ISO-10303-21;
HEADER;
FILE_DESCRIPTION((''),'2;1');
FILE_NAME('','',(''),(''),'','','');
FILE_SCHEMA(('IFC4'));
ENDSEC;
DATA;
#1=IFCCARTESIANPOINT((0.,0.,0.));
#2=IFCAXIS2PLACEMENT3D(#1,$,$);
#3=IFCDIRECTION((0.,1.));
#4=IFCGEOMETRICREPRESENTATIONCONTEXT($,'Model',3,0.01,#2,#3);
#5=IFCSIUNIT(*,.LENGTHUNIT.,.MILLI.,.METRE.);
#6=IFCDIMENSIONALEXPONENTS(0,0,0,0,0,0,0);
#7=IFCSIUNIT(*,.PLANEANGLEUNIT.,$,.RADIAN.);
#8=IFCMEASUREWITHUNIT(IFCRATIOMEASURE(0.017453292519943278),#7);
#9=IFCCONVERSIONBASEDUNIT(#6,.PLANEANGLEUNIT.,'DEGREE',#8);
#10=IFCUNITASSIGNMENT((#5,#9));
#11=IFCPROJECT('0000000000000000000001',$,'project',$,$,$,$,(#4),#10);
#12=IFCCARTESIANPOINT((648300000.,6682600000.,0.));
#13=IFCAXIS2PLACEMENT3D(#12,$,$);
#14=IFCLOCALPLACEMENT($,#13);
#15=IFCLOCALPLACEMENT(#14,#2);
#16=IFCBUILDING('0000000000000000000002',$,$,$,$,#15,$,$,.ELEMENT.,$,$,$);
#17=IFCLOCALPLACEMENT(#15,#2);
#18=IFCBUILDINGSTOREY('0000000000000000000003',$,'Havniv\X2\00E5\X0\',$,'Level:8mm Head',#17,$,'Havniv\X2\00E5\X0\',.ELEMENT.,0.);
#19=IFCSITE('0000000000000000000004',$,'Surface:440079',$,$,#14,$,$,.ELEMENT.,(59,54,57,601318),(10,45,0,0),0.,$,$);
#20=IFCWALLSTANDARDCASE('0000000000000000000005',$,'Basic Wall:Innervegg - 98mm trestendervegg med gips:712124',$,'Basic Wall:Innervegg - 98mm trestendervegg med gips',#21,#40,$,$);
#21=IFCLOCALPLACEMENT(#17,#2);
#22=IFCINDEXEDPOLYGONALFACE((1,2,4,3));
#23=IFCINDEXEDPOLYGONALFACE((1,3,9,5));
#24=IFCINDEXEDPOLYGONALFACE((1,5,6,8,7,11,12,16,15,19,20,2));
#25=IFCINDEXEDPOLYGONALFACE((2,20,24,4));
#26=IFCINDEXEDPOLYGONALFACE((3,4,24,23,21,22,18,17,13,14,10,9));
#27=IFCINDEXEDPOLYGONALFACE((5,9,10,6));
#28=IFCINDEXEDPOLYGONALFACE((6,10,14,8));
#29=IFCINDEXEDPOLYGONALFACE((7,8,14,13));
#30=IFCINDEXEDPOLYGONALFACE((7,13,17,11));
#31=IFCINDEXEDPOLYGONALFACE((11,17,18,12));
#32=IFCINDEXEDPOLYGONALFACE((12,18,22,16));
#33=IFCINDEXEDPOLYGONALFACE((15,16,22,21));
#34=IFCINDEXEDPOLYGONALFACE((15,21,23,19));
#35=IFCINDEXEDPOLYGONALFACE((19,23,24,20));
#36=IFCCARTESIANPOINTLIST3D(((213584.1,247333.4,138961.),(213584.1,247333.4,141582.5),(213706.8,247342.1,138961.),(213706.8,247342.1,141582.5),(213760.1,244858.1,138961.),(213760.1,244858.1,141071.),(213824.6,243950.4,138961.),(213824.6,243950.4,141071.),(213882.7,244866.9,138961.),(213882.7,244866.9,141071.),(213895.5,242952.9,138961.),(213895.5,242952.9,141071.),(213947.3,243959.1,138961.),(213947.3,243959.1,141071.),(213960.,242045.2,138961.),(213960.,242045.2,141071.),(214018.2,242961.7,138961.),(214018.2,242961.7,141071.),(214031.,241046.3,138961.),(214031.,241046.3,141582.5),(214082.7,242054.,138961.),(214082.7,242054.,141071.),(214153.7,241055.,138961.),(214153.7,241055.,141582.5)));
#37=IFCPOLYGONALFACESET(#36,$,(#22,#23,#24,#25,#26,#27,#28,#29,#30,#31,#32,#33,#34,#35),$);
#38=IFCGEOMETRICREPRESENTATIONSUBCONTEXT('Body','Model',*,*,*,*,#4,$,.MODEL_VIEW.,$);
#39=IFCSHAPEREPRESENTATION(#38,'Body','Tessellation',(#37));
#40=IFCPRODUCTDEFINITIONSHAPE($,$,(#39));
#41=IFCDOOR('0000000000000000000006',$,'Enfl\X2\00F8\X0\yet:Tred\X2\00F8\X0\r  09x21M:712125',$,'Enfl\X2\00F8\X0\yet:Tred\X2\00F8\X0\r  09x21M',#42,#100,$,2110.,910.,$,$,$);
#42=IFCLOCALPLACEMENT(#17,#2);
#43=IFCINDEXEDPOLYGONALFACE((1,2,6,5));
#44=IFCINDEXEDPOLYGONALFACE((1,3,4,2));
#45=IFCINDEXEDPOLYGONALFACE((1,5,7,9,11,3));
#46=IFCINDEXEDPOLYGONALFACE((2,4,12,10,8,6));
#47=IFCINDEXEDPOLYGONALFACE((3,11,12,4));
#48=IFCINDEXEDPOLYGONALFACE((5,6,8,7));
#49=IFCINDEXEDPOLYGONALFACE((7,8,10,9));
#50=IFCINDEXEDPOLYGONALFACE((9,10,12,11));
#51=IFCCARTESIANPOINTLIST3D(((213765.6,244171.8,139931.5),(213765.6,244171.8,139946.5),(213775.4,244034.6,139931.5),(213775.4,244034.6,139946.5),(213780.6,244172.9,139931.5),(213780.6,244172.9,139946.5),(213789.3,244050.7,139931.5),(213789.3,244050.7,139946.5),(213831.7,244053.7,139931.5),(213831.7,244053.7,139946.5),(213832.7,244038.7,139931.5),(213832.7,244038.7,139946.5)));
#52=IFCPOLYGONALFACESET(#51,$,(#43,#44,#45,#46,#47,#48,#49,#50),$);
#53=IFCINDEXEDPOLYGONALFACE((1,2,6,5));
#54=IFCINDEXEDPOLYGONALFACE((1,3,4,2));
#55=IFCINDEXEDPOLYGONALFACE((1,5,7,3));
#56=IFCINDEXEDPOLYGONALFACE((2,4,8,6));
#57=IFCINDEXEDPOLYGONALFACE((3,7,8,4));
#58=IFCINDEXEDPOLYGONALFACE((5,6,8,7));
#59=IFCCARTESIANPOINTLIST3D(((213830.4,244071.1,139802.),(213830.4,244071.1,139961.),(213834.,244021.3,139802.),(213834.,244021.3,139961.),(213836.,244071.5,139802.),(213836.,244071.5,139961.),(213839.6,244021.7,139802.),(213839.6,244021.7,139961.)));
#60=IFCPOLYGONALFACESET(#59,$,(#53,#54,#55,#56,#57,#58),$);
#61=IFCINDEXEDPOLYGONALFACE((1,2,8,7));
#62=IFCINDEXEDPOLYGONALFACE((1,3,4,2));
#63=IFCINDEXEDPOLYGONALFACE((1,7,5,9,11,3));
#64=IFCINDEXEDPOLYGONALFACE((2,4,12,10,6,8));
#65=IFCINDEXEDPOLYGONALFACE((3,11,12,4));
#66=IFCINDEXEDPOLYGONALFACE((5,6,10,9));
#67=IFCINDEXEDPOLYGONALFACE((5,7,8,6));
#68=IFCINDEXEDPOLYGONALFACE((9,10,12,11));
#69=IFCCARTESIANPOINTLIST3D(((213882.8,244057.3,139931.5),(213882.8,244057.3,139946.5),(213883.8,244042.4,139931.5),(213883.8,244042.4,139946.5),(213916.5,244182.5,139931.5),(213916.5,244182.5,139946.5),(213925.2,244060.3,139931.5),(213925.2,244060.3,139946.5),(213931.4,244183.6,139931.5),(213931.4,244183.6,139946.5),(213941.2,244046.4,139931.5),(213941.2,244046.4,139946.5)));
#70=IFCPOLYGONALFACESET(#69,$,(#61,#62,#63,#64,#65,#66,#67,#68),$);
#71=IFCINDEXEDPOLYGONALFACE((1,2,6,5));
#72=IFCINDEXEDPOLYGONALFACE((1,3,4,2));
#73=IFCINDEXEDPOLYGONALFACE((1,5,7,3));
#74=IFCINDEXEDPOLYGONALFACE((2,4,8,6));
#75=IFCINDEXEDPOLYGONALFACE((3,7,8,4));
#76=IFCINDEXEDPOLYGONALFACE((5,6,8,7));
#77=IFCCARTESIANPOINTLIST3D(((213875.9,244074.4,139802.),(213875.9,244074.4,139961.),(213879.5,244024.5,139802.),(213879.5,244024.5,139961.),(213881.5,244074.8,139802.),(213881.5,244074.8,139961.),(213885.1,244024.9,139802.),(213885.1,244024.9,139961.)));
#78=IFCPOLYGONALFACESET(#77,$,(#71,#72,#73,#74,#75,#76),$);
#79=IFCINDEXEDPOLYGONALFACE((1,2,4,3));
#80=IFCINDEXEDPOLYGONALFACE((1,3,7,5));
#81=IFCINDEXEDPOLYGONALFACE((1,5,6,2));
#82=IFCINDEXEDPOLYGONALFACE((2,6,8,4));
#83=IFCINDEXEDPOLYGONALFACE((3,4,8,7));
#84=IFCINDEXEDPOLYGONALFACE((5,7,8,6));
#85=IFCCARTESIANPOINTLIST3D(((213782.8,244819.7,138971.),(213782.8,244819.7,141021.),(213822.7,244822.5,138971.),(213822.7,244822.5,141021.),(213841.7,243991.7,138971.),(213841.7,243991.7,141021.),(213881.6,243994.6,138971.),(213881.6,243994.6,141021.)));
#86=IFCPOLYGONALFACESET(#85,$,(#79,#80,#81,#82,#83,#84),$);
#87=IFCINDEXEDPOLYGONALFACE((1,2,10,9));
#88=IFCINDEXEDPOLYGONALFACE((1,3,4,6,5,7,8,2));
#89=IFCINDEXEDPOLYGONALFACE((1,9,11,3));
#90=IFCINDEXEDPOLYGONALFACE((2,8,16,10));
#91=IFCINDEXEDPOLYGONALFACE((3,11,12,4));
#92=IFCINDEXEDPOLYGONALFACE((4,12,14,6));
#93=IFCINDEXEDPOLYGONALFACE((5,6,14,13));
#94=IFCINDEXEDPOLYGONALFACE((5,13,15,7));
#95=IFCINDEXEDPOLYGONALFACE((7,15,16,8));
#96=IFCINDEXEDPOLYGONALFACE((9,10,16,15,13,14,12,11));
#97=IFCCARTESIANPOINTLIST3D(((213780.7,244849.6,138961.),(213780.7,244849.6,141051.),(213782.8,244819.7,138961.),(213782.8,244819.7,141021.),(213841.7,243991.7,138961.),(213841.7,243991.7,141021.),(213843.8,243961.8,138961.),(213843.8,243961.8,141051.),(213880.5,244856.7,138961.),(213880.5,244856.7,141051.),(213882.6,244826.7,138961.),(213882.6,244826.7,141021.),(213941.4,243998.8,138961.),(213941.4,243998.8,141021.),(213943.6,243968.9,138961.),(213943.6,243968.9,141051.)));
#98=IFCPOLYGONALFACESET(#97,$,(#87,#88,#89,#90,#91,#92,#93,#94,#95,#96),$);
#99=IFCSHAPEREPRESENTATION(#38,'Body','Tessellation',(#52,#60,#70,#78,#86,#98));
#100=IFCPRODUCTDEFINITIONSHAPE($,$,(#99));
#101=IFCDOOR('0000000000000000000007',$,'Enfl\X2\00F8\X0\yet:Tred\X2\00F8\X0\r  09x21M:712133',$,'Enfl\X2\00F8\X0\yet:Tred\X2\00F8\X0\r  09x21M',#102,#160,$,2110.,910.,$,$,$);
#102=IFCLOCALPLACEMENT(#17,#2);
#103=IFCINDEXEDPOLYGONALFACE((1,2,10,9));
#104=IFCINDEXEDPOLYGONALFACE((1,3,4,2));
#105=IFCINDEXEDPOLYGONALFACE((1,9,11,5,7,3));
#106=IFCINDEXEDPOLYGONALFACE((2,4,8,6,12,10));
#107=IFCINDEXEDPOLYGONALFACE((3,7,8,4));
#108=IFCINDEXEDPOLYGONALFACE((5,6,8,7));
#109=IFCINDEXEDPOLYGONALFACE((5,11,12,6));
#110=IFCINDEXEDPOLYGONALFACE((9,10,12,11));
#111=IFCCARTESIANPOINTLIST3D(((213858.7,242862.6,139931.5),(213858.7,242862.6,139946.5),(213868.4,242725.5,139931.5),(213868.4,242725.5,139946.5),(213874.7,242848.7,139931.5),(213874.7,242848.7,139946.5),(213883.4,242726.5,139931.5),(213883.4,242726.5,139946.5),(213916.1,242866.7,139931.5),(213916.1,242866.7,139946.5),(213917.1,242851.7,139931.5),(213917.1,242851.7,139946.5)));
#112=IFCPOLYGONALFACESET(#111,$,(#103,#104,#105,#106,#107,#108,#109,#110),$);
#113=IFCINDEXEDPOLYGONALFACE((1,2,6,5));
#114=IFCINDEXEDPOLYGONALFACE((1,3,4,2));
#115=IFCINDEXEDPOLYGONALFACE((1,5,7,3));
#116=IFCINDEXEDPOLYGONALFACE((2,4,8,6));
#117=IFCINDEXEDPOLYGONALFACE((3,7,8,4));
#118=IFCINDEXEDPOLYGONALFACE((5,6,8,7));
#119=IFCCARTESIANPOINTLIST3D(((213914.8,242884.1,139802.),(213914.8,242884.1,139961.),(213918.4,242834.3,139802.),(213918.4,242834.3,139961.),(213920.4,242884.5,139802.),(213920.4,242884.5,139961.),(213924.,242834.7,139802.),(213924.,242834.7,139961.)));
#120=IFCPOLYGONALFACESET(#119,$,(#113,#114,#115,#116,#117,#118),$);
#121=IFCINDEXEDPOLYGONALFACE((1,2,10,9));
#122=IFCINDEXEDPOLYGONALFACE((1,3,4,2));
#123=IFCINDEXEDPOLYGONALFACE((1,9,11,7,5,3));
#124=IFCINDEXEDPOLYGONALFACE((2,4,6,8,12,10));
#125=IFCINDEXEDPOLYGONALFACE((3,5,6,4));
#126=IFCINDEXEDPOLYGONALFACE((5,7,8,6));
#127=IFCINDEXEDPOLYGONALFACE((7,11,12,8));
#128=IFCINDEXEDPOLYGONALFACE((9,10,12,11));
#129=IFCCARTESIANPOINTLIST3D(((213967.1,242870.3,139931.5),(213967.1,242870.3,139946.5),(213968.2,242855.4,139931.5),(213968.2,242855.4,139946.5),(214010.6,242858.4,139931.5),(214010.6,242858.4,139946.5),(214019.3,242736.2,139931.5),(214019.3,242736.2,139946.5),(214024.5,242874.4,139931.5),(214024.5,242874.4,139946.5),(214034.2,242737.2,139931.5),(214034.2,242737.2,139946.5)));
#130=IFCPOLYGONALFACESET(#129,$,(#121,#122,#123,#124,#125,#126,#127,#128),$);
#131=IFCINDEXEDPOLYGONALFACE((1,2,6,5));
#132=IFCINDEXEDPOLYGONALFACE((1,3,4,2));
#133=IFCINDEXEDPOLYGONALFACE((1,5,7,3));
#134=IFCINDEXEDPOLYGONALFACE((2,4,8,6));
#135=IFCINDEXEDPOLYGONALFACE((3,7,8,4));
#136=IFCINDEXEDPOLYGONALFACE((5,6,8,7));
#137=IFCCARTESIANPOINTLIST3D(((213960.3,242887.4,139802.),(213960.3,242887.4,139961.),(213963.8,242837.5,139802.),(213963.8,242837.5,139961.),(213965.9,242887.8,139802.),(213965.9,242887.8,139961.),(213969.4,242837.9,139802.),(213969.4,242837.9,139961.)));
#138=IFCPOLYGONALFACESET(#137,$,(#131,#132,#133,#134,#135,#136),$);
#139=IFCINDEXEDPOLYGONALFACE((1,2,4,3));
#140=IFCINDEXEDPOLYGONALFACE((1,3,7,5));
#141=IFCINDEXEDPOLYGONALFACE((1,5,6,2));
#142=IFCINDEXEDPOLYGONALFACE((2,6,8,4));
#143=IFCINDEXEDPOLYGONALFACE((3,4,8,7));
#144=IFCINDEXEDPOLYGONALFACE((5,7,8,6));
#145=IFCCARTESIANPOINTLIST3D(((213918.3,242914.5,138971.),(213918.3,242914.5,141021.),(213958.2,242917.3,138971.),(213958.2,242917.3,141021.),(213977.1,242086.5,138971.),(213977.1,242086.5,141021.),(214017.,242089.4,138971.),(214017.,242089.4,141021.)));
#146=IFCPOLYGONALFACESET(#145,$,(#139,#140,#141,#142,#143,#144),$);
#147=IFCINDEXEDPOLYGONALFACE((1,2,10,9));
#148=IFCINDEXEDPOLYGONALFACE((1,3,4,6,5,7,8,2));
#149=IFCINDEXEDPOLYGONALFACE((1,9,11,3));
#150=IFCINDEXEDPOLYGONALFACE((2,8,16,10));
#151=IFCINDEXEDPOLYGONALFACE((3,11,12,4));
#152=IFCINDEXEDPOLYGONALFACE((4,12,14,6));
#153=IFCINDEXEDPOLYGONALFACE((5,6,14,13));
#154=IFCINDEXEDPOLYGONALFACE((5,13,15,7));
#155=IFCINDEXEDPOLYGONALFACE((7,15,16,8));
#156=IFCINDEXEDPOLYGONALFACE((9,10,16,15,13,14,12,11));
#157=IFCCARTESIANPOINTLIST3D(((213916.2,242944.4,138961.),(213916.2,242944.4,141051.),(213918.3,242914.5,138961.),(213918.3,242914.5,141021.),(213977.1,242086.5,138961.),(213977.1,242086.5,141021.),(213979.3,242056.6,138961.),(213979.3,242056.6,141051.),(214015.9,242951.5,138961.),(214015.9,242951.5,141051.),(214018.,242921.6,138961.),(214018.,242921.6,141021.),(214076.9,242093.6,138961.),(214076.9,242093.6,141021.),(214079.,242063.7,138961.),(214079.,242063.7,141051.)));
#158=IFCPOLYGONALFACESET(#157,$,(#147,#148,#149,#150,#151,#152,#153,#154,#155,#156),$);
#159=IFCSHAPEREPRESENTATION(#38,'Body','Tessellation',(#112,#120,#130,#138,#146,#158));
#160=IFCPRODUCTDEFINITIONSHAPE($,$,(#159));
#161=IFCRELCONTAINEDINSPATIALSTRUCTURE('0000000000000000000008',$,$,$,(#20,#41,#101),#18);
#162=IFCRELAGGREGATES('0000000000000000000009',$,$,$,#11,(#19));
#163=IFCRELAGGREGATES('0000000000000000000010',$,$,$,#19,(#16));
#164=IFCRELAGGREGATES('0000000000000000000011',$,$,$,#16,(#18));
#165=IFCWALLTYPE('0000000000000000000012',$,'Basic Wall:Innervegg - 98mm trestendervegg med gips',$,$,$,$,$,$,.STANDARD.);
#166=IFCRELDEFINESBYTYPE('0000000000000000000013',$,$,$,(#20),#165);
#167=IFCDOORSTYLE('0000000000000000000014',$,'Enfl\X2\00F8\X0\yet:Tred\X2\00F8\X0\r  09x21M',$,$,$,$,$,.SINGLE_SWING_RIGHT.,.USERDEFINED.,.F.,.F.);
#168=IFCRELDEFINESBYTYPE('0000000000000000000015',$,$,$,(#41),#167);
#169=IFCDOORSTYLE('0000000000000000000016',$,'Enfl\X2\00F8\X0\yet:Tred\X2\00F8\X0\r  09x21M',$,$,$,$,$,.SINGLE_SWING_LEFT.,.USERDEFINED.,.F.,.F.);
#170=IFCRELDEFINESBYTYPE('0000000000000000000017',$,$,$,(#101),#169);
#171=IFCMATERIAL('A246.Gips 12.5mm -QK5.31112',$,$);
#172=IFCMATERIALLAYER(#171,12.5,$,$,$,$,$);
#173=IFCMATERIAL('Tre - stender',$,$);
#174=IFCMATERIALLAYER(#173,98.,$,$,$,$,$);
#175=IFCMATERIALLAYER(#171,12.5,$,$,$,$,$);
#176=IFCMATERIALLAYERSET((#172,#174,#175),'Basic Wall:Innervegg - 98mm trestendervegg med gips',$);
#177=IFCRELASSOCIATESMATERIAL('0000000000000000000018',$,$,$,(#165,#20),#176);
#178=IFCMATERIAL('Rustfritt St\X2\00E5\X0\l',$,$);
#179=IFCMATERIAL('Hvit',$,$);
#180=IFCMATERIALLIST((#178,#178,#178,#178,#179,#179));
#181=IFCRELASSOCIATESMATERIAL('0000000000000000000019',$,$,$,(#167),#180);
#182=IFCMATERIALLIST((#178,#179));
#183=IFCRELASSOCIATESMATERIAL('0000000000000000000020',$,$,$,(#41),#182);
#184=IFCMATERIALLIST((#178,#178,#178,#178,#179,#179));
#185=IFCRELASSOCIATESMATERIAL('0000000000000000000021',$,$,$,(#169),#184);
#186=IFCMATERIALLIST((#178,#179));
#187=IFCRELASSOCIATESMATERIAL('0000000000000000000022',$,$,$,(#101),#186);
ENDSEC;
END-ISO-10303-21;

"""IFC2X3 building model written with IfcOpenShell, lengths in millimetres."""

from ifc_helpers import new_model, entity, si_unit, converted_unit, direction, frame, frame_2d, origin, origin_2d_with_axis, place, context, subcontext, project, spatial, polyline, rectangle, outline, extrude, clip, bounded_halfspace, source, transform, mapped, material, material_list, layer, layer_set, layer_usage, type_object, type_shapes, element, fill, save


model = new_model("IFC2X3")

# Units and contexts
model_context = context("Model", 3, precision=0.01, world=origin(), true_north=direction((0.0, 1.0)))
body_context = subcontext(model_context, "Body", "Model", "MODEL_VIEW")
ifc_project = project(units=[si_unit("LENGTHUNIT", "METRE", prefix="MILLI"), converted_unit("PLANEANGLEUNIT", "DEGREE", entity("IfcRatioMeasure", 0.017453292519943278), si_unit("PLANEANGLEUNIT", "RADIAN"), dimensions=[0, 0, 0, 0, 0, 0, 0])], contexts=[model_context])

# Site, building, storey
site_placement = place(None, frame((648300000.0, 6682600000.0, 0.0)))
site = spatial("IfcSite", under=ifc_project, at=site_placement, Name="Surface:440079", CompositionType="ELEMENT", RefLatitude=(59, 54, 57, 601318), RefLongitude=(10, 45, 0, 0), RefElevation=0.0)
building_placement = place(site_placement, origin())
building = spatial("IfcBuilding", under=site, at=building_placement, CompositionType="ELEMENT")
storey_placement = place(building_placement, origin())
storey = spatial("IfcBuildingStorey", under=building, at=storey_placement, Name="Havnivå", ObjectType="Level:8mm Head", LongName="Havnivå", CompositionType="ELEMENT", Elevation=0.0)

# Shared definitions
ifc_material_1 = material(Name="A246.Gips 12.5mm -QK5.31112")

# Wall, openings, doors
ifc_layer_1 = layer(ifc_material_1, 12.5)
ifc_material_2 = material(Name="Tre - stender")
ifc_layer_2 = layer(ifc_material_2, 98.0)
ifc_layer_3 = layer(ifc_material_1, 12.5)
ifc_layer_set_1 = layer_set([ifc_layer_1, ifc_layer_2, ifc_layer_3], Name="Basic Wall:Innervegg - 98mm trestendervegg med gips")
ifc_layer_usage_1 = layer_usage(ifc_layer_set_1, "AXIS2", "POSITIVE", -61.5)
wall_type_1 = type_object("IfcWallType", Name="Basic Wall:Innervegg - 98mm trestendervegg med gips", PredefinedType="STANDARD", material=ifc_layer_set_1)
wall_1_placement = place(storey_placement, frame((214092.4, 241050.6, 138961.0), z_axis=(0.0, 0.0, 1.0), x_axis=(-0.070908, 0.997483, 0.0)))
wall_1 = element("IfcWallStandardCase", 1, at=wall_1_placement, inside=storey, type_object=wall_type_1, material=ifc_layer_usage_1, Name="Basic Wall:Innervegg - 98mm trestendervegg med gips:712124", ObjectType="Basic Wall:Innervegg - 98mm trestendervegg med gips", context=body_context, shape_type="Clipping", body=[
    clip(extrude(rectangle(XDim=6303.0, YDim=123.0, at=frame_2d((3151.5, 0.0), x_axis=(1.0, 0.0))), origin(), (0.0, 0.0, 1.0), 2621.5), bounded_halfspace(frame((0.0, -61.5, 2621.5), z_axis=(0.0, 0.0, -1.0), x_axis=(0.0, 1.0, 0.0)), True, frame((0.0, -61.5, 2621.5)), polyline([(0.0, 0.0), (37490.4, 0.0), (685800.0, 0.0), (723290.4, 0.0), (1921154.4, 0.0), (1921154.4, 37490.4), (128930.4, 37490.4), (91440.0, 37490.4), (0.0, 37490.4), (0.0, 0.0)]))),
])
opening_1_placement = place(wall_1_placement, frame((2911.5, -61.5, 0.0)))
opening_1 = element("IfcOpeningElement", 2, at=opening_1_placement, cuts=wall_1, ObjectType="Opening", context=body_context, shape_type="SweptSolid", body=[
    extrude(rectangle(XDim=2110.0, YDim=910.0, at=frame_2d((1055.0, 455.0), x_axis=(1.0, 0.0))), frame((0.0, 0.0, 0.0), z_axis=(0.0, 1.0, 0.0), x_axis=(0.0, 0.0, 1.0)), (0.0, 0.0, 1.0), 123.0),
])
opening_2_placement = place(wall_1_placement, frame((1001.5, -61.5, 0.0)))
opening_2 = element("IfcOpeningElement", 3, at=opening_2_placement, cuts=wall_1, ObjectType="Opening", context=body_context, shape_type="SweptSolid", body=[
    extrude(rectangle(XDim=2110.0, YDim=910.0, at=frame_2d((1055.0, 455.0), x_axis=(1.0, 0.0))), frame((0.0, 0.0, 0.0), z_axis=(0.0, 1.0, 0.0), x_axis=(0.0, 0.0, 1.0)), (0.0, 0.0, 1.0), 123.0),
])
ifc_material_3 = material(Name="Rustfritt Stål")
ifc_material_4 = material(Name="Hvit")
ifc_material_list_1 = material_list([ifc_material_3, ifc_material_4])
ifc_material_list_2 = material_list([ifc_material_3, ifc_material_3, ifc_material_3, ifc_material_3, ifc_material_4, ifc_material_4])
door_style_1 = type_object("IfcDoorStyle", Name="Enfløyet:Tredør  09x21M", ConstructionType="USERDEFINED", OperationType="SINGLE_SWING_RIGHT", ParameterTakesPrecedence=False, Sizeable=False, material=ifc_material_list_2)
shared_shape_1 = source(origin(), body_context, "Body", "SweptSolid", [
    extrude(outline(polyline([(-50.8, -33.3), (-35.8, -33.3), (-35.8, 9.2), (86.7, 9.2), (86.7, 24.2), (-50.8, 24.2), (-50.8, -33.3)])), frame((138.3, 141.9, 970.5)), (0.0, 0.0, 1.0), 15.0),
    extrude(rectangle(XDim=50.0, YDim=5.6, at=frame_2d((0.0, 0.0), x_axis=(1.0, 0.0))), frame((95.0, 105.8, 841.0), z_axis=(0.0, 0.0, 1.0), x_axis=(-1.0, 0.0, 0.0)), (0.0, 0.0, 1.0), 159.0),
    extrude(outline(polyline([(-33.3, -50.8), (24.2, -50.8), (24.2, 86.7), (9.2, 86.7), (9.2, -35.8), (-33.3, -35.8), (-33.3, -50.8)])), frame((138.3, 24.1, 970.5), z_axis=(0.0, 0.0, 1.0), x_axis=(0.0, -1.0, 0.0)), (0.0, 0.0, 1.0), 15.0),
    extrude(rectangle(XDim=5.6, YDim=50.0, at=frame_2d((0.0, 0.0), x_axis=(1.0, 0.0))), frame((95.0, 60.2, 841.0), z_axis=(0.0, 0.0, 1.0), x_axis=(0.0, 1.0, 0.0)), (0.0, 0.0, 1.0), 159.0),
    extrude(rectangle(XDim=40.0, YDim=830.0, at=origin_2d_with_axis()), frame((455.0, 83.0, 10.0), z_axis=(0.0, 0.0, 1.0), x_axis=(0.0, -1.0, 0.0)), (0.0, 0.0, 1.0), 2050.0),
    extrude(outline(polyline([(-1037.5, -445.0), (1052.5, -445.0), (1052.5, 445.0), (-1037.5, 445.0), (-1037.5, 415.0), (1022.5, 415.0), (1022.5, -415.0), (-1037.5, -415.0), (-1037.5, -445.0)])), frame((455.0, 3.0, 1037.5), z_axis=(0.0, 1.0, 0.0), x_axis=(0.0, 0.0, 1.0)), (0.0, 0.0, 1.0), 100.0),
])
type_shapes(door_style_1, [shared_shape_1])
door_1_placement = place(opening_1_placement, origin())
door_1 = element("IfcDoor", 4, at=door_1_placement, inside=storey, type_object=door_style_1, material=ifc_material_list_1, Name="Enfløyet:Tredør  09x21M:712125", ObjectType="Enfløyet:Tredør  09x21M", OverallHeight=2110.0, OverallWidth=910.0, context=body_context, shape_type="MappedRepresentation", body=[
    mapped(shared_shape_1, transform((0.0, 0.0, 0.0), scale=1.0)),
])
fill(opening_1, door_1)
ifc_material_list_3 = material_list([ifc_material_3, ifc_material_4])
ifc_material_list_4 = material_list([ifc_material_3, ifc_material_3, ifc_material_3, ifc_material_3, ifc_material_4, ifc_material_4])
door_style_2 = type_object("IfcDoorStyle", Name="Enfløyet:Tredør  09x21M", ConstructionType="USERDEFINED", OperationType="SINGLE_SWING_LEFT", ParameterTakesPrecedence=False, Sizeable=False, material=ifc_material_list_4)
shared_shape_2 = source(origin(), body_context, "Body", "SweptSolid", [
    extrude(outline(polyline([(-33.3, -50.8), (24.2, -50.8), (24.2, 86.7), (9.2, 86.7), (9.2, -35.8), (-33.3, -35.8), (-33.3, -50.8)])), frame((771.7, 121.9, 970.5), z_axis=(0.0, 0.0, 1.0), x_axis=(0.0, 1.0, 0.0)), (0.0, 0.0, 1.0), 15.0),
    extrude(rectangle(XDim=5.6, YDim=50.0, at=frame_2d((0.0, 0.0), x_axis=(1.0, 0.0))), frame((815.0, 85.8, 841.0), z_axis=(0.0, 0.0, 1.0), x_axis=(0.0, -1.0, 0.0)), (0.0, 0.0, 1.0), 159.0),
    extrude(outline(polyline([(-50.8, -33.3), (-35.8, -33.3), (-35.8, 9.2), (86.7, 9.2), (86.7, 24.2), (-50.8, 24.2), (-50.8, -33.3)])), frame((771.7, 4.1, 970.5), z_axis=(0.0, 0.0, 1.0), x_axis=(-1.0, 0.0, 0.0)), (0.0, 0.0, 1.0), 15.0),
    extrude(rectangle(XDim=50.0, YDim=5.6, at=frame_2d((0.0, 0.0), x_axis=(1.0, 0.0))), frame((815.0, 40.2, 841.0)), (0.0, 0.0, 1.0), 159.0),
    extrude(rectangle(XDim=830.0, YDim=40.0, at=origin_2d_with_axis()), frame((455.0, 63.0, 10.0), z_axis=(0.0, 0.0, 1.0), x_axis=(-1.0, 0.0, 0.0)), (0.0, 0.0, 1.0), 2050.0),
    extrude(outline(polyline([(415.0, -1037.5), (445.0, -1037.5), (445.0, 1052.5), (-445.0, 1052.5), (-445.0, -1037.5), (-415.0, -1037.5), (-415.0, 1022.5), (415.0, 1022.5), (415.0, -1037.5)])), frame((455.0, 83.0, 1037.5), z_axis=(0.0, -1.0, 0.0), x_axis=(1.0, 0.0, 0.0)), (0.0, 0.0, 1.0), 100.0),
])
type_shapes(door_style_2, [shared_shape_2])
door_2_placement = place(opening_2_placement, frame((0.0, 20.0, 0.0)))
door_2 = element("IfcDoor", 5, at=door_2_placement, inside=storey, type_object=door_style_2, material=ifc_material_list_3, Name="Enfløyet:Tredør  09x21M:712133", ObjectType="Enfløyet:Tredør  09x21M", OverallHeight=2110.0, OverallWidth=910.0, context=body_context, shape_type="MappedRepresentation", body=[
    mapped(shared_shape_2, transform((0.0, 0.0, 0.0), scale=1.0)),
])
fill(opening_2, door_2)

save(model, "model.ifc")
